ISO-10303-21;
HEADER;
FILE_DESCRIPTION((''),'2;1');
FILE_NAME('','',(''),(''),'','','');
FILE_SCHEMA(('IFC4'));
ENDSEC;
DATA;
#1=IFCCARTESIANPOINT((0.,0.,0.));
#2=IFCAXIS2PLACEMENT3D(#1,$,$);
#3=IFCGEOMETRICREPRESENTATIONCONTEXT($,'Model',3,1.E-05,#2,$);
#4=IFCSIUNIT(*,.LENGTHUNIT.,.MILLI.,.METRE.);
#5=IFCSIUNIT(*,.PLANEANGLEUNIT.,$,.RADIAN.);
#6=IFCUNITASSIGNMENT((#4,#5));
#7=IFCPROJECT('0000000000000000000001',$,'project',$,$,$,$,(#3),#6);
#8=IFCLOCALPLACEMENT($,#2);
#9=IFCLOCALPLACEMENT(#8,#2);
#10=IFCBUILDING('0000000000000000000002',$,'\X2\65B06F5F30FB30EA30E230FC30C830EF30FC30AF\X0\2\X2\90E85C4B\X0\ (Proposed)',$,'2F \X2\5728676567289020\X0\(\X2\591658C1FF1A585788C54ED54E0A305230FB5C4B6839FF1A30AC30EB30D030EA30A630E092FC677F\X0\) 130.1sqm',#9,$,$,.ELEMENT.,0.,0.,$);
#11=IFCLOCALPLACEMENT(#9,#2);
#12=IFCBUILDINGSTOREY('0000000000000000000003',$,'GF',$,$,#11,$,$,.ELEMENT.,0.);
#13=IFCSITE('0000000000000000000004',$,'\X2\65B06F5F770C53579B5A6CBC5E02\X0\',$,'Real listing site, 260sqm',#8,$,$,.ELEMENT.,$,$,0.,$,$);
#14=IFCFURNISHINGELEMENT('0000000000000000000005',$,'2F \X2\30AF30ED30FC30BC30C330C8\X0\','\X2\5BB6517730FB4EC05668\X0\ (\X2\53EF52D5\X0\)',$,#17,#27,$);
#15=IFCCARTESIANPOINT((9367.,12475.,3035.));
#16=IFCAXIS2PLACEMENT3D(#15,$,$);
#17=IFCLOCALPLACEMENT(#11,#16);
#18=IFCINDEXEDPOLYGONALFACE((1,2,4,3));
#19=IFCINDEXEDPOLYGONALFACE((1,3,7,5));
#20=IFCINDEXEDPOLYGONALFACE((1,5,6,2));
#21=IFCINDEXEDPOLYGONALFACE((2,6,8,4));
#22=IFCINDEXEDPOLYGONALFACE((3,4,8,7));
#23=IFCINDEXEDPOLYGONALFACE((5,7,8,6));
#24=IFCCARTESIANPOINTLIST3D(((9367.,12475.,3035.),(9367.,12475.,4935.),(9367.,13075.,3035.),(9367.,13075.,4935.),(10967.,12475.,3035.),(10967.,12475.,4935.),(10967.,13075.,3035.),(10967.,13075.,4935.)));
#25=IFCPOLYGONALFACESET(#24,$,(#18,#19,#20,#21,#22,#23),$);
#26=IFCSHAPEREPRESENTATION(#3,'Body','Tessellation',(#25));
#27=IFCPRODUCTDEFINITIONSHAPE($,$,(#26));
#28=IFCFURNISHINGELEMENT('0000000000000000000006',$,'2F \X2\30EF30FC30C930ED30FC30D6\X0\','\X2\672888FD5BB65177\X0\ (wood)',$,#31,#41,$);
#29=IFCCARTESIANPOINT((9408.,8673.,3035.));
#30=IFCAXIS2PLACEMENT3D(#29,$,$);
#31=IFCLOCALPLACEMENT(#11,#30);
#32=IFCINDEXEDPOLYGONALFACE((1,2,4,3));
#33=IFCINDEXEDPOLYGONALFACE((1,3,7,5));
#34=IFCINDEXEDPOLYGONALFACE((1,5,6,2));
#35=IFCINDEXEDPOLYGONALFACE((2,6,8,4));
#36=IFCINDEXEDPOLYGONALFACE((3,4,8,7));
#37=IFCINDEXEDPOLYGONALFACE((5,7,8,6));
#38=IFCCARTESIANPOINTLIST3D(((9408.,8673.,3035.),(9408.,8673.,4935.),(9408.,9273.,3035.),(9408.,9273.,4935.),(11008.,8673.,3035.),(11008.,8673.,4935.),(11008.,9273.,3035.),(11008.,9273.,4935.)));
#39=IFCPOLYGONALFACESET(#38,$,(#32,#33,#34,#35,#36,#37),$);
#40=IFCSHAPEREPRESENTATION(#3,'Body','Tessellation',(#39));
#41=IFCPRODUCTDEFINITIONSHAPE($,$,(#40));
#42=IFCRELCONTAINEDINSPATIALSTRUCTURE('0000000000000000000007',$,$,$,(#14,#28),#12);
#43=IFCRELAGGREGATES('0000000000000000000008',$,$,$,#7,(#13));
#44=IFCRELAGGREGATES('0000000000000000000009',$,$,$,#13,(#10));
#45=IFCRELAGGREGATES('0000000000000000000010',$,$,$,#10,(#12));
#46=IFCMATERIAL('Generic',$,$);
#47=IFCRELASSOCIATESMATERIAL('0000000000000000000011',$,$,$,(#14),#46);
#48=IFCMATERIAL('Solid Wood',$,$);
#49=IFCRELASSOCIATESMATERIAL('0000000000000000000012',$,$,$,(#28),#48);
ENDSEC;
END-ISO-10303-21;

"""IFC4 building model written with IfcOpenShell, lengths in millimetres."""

from ifc_helpers import new_model, si_unit, frame, frame_2d, origin, place, context, project, spatial, rectangle, extrude, material, element, save


model = new_model("IFC4")

# Units and contexts
model_context = context("Model", 3, precision=1e-05, world=origin())
ifc_project = project(units=[si_unit("LENGTHUNIT", "METRE", prefix="MILLI"), si_unit("PLANEANGLEUNIT", "RADIAN")], contexts=[model_context])

# Site, building, storey
site_placement = place(None, origin())
site = spatial("IfcSite", under=ifc_project, at=site_placement, Name="新潟県南魚沼市", ObjectType="Real listing site, 260sqm", CompositionType="ELEMENT", RefElevation=0.0)
building_placement = place(site_placement, origin())
building = spatial("IfcBuilding", under=site, at=building_placement, Name="新潟・リモートワーク2部屋 (Proposed)", ObjectType="2F 在来木造(外壁：塗装仕上げ・屋根：ガルバリウム鋼板) 130.1sqm", CompositionType="ELEMENT", ElevationOfRefHeight=0.0, ElevationOfTerrain=0.0)
storey_placement = place(building_placement, origin())
storey = spatial("IfcBuildingStorey", under=building, at=storey_placement, Name="GF", CompositionType="ELEMENT", Elevation=0.0)

# Shared definitions
ifc_material_1 = material(Name="Solid Wood")

# Shared definitions
ifc_material_2 = material(Name="Generic")

# Furnishing elements
furnishing_1_placement = place(storey_placement, frame((9367.0, 12475.0, 3035.0)))
element("IfcFurnishingElement", 1, at=furnishing_1_placement, inside=storey, material=ifc_material_2, Name="2F クローゼット", Description="家具・什器 (可動)", context=model_context, shape_type="SweptSolid", body=[
    extrude(rectangle(XDim=1600.0, YDim=600.0, at=frame_2d((800.0, 300.0))), frame((9367.0, 12475.0, 3035.0)), (0.0, 0.0, 1.0), 1900.0),
])
furnishing_2_placement = place(storey_placement, frame((9408.0, 8673.0, 3035.0)))
element("IfcFurnishingElement", 2, at=furnishing_2_placement, inside=storey, material=ifc_material_1, Name="2F ワードローブ", Description="木製家具 (wood)", context=model_context, shape_type="SweptSolid", body=[
    extrude(rectangle(XDim=1600.0, YDim=600.0, at=frame_2d((800.0, 300.0))), frame((9408.0, 8673.0, 3035.0)), (0.0, 0.0, 1.0), 1900.0),
])

save(model, "model.ifc")
